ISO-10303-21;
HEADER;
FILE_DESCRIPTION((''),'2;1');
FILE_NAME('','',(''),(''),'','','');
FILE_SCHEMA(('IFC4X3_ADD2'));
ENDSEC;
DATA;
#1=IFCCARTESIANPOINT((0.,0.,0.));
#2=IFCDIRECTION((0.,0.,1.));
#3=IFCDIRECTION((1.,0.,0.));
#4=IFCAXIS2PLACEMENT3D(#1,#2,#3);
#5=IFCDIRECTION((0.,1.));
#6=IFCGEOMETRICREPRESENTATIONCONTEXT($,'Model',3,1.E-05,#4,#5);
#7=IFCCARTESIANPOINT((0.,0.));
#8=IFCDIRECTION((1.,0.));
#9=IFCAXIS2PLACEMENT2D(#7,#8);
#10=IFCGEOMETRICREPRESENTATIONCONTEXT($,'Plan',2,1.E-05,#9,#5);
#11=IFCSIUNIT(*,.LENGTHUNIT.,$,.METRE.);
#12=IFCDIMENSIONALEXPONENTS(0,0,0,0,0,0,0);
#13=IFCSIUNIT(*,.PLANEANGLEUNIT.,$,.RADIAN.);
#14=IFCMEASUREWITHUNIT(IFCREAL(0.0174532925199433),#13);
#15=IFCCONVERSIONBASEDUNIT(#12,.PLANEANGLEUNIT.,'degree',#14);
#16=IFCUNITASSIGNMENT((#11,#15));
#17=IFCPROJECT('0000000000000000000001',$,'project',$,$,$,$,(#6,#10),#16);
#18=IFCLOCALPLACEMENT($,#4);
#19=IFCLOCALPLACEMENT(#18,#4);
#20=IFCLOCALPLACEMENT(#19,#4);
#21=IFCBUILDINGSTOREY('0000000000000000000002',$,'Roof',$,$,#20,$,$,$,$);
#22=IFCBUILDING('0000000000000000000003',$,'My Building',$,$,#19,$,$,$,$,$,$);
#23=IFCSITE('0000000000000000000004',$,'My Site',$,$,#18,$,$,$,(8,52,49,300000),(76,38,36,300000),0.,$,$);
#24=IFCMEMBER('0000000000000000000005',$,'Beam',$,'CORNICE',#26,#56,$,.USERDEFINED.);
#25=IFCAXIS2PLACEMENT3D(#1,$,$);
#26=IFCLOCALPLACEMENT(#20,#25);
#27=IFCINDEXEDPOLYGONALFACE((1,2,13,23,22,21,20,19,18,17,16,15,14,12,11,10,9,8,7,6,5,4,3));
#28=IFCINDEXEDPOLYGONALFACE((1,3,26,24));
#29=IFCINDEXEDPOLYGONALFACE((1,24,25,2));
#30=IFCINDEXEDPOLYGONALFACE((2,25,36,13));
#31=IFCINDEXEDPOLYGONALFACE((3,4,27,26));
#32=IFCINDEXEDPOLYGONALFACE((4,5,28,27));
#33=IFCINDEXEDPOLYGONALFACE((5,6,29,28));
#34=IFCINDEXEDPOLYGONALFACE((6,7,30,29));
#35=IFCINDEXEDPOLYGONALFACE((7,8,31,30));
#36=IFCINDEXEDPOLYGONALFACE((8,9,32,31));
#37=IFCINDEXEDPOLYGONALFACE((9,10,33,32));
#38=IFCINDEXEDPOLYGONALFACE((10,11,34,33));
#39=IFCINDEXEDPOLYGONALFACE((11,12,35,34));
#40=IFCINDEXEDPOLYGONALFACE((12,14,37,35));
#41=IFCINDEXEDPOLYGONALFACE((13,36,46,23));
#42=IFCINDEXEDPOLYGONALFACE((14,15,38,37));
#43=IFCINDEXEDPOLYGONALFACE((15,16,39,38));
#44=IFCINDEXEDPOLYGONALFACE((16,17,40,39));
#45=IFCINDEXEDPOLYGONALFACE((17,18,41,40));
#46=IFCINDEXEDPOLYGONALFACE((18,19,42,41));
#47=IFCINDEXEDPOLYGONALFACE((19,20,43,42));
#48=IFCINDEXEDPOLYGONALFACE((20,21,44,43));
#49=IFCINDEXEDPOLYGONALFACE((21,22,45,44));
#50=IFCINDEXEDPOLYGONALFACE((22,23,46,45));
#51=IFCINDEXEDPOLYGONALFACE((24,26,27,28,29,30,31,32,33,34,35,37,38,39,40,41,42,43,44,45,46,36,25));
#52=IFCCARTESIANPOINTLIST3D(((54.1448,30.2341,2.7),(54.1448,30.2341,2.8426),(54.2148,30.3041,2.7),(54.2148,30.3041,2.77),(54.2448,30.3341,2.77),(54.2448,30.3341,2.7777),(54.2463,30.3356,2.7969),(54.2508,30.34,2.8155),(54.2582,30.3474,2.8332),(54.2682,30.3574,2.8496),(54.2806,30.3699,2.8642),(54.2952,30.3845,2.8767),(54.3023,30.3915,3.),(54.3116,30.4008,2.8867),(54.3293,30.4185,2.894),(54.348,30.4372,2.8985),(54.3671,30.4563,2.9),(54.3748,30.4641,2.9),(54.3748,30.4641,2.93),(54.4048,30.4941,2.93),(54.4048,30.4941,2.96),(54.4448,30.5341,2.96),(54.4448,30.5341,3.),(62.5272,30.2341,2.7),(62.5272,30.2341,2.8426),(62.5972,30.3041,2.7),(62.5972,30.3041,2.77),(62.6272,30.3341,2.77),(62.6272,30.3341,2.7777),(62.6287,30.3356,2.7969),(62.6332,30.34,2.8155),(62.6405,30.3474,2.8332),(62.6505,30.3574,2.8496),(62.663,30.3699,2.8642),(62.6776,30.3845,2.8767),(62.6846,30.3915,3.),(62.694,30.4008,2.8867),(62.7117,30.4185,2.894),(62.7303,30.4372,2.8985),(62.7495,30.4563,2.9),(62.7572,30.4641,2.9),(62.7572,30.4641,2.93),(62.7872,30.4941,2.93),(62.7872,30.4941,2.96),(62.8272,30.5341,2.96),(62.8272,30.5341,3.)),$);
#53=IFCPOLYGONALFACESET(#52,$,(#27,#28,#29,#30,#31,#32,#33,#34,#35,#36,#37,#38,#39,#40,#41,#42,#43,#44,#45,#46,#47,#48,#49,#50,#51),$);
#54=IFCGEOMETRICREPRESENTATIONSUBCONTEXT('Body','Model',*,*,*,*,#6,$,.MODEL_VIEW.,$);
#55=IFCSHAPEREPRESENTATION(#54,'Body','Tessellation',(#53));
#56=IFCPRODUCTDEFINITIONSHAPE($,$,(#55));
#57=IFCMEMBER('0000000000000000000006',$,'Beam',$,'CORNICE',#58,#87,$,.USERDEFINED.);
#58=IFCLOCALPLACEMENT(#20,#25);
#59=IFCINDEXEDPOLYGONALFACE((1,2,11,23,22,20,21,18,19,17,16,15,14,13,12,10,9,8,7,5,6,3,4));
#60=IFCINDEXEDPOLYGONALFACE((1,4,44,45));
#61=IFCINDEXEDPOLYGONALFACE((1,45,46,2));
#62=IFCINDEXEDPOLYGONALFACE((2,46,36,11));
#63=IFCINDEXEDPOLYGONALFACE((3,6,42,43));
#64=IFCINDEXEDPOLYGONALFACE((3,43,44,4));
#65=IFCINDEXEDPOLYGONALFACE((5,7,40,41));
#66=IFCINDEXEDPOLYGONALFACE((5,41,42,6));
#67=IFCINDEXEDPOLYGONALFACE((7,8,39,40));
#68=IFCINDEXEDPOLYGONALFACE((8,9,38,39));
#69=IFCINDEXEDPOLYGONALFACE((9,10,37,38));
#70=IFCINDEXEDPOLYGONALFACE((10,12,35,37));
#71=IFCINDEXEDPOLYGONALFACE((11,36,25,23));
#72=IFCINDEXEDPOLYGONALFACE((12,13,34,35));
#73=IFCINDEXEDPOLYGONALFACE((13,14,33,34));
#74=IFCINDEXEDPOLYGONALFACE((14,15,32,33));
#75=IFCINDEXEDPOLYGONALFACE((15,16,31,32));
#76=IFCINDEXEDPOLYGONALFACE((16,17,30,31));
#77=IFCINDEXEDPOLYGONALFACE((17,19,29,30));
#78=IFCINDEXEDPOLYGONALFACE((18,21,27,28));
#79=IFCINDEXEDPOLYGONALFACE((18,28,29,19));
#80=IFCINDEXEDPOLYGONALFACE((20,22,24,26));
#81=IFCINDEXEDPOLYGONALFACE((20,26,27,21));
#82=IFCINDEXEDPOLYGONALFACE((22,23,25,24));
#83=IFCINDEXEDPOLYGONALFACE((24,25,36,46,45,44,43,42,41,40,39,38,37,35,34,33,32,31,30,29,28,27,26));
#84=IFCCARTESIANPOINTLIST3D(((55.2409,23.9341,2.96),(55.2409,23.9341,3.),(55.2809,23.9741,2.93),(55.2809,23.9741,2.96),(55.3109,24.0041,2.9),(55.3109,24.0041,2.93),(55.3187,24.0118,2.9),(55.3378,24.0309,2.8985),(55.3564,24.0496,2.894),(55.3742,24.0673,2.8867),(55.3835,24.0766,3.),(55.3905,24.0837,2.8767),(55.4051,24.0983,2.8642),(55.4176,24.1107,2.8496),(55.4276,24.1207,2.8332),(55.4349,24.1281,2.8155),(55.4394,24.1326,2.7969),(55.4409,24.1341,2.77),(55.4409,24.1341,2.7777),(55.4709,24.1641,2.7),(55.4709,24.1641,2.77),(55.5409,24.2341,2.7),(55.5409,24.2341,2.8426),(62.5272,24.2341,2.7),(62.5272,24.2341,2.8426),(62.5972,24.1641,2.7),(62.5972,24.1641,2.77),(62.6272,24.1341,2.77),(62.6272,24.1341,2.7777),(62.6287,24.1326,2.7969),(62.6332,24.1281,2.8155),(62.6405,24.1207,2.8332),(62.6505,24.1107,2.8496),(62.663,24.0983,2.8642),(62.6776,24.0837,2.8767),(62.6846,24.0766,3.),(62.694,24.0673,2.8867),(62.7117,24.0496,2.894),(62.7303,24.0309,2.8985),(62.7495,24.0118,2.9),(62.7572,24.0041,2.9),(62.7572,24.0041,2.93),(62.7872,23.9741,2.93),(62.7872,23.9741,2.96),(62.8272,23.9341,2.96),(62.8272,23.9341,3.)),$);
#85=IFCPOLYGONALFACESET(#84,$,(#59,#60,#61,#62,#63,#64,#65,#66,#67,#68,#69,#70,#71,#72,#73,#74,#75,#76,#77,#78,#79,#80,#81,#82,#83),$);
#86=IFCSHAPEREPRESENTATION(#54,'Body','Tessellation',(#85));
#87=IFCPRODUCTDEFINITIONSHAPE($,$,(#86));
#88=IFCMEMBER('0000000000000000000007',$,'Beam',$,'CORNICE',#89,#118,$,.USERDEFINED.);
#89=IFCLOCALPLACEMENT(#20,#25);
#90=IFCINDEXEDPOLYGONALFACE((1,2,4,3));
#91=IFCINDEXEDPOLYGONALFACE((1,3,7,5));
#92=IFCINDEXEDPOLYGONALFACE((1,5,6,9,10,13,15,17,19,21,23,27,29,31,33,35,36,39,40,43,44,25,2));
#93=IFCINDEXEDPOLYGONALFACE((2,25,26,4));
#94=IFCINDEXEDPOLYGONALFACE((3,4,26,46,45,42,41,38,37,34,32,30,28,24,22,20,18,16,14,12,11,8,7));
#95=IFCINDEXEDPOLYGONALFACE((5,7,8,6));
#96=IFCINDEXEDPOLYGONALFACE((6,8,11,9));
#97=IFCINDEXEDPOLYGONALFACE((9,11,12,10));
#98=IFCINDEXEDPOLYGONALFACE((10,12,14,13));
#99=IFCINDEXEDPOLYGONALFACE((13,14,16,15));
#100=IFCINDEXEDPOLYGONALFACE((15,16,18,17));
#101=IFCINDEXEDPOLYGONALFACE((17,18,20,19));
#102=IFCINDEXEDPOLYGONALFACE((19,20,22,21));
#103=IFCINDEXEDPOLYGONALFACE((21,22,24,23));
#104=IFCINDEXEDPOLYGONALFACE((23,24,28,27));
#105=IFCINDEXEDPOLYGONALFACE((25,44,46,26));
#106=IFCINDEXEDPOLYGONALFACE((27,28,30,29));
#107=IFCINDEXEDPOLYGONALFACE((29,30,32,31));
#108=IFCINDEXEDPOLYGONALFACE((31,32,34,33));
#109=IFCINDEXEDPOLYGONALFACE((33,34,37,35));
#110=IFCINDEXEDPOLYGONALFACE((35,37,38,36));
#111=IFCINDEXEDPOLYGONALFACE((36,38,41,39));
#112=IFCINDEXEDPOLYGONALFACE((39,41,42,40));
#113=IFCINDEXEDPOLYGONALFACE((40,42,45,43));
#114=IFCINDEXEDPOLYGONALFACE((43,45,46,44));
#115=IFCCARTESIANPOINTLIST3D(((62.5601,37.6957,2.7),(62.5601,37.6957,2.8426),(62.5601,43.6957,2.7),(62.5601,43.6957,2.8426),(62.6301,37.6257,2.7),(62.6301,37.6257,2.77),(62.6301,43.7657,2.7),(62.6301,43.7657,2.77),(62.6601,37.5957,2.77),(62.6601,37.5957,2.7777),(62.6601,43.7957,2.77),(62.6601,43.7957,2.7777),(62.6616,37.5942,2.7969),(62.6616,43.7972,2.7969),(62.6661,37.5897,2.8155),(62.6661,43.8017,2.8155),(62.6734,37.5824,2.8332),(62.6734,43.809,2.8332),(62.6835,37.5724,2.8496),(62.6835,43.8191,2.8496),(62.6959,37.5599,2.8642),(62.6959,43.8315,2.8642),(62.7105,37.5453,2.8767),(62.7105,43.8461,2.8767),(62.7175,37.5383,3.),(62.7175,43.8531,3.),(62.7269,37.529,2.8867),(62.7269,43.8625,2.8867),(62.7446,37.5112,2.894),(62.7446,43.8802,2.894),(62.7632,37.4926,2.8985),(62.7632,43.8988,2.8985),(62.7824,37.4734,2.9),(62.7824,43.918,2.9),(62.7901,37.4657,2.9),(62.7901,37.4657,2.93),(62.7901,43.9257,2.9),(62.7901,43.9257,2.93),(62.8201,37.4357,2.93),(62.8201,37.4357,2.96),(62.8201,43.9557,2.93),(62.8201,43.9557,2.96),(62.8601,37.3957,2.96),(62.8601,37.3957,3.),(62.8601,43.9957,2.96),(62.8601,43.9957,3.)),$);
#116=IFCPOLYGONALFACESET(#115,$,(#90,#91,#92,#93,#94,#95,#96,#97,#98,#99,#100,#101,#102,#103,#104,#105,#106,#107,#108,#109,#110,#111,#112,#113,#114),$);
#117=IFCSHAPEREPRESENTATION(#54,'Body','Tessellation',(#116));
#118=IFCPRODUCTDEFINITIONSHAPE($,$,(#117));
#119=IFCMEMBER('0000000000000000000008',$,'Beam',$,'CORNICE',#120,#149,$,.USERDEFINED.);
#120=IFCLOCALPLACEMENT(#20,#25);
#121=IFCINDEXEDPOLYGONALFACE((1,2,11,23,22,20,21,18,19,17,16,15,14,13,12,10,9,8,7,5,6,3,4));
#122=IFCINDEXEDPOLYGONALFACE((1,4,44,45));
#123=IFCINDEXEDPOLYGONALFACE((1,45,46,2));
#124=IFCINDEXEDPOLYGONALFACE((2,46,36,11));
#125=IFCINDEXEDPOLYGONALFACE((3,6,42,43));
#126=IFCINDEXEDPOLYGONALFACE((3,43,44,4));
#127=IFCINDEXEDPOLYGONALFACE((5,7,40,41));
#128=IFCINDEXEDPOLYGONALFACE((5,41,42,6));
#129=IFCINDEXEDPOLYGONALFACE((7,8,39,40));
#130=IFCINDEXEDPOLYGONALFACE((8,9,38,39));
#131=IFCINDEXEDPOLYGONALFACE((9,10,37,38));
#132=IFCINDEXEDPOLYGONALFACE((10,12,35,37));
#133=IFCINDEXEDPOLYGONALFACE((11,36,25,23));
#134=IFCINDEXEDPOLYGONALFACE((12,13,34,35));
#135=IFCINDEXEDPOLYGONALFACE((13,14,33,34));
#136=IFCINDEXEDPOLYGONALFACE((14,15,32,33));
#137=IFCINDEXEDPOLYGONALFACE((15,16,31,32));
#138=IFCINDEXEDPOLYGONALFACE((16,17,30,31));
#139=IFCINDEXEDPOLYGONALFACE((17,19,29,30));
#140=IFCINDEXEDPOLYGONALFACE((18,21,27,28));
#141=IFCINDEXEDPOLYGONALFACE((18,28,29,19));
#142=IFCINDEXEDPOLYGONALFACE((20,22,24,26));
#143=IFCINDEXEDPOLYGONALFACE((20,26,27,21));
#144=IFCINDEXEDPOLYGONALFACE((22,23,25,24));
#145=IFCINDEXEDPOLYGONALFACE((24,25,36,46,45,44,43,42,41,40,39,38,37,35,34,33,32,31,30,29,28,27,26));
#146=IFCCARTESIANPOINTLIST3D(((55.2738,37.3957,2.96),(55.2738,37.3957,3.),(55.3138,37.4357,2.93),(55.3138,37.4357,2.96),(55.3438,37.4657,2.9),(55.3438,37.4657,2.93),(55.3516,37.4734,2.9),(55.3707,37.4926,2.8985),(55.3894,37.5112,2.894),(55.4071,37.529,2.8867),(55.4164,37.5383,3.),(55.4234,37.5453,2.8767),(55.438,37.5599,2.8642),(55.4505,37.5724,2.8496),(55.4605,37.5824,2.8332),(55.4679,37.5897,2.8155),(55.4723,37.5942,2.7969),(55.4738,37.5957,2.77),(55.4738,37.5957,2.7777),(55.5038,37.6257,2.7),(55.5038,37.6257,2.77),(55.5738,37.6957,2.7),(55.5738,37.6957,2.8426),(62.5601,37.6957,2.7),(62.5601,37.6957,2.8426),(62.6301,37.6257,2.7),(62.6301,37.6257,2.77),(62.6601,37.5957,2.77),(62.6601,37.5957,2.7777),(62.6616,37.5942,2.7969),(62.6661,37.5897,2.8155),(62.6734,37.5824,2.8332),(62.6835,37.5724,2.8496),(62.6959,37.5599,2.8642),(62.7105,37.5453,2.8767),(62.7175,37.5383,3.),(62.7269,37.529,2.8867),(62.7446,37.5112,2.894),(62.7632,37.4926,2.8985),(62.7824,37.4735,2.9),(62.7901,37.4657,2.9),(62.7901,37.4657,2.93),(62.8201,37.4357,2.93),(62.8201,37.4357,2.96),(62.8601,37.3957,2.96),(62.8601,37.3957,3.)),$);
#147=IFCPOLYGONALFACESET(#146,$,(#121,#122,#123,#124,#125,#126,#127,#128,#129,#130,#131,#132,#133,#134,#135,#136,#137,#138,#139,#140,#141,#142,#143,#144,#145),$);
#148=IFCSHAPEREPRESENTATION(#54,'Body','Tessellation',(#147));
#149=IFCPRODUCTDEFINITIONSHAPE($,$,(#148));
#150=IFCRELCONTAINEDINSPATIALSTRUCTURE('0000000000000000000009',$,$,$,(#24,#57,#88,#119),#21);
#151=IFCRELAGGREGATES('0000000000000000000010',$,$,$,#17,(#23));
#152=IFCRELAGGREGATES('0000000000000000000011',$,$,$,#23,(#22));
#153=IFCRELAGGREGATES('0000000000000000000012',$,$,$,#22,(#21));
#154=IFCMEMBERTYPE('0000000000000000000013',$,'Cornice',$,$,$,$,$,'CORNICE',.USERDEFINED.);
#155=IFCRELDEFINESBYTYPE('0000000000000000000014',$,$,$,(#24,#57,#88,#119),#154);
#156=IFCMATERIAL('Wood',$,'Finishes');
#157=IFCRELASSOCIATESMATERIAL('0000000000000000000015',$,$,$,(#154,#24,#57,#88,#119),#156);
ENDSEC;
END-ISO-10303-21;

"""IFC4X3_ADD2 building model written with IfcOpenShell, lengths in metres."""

from ifc_helpers import new_model, entity, si_unit, converted_unit, direction, frame, origin_with_axes, origin_2d_with_axis, place, context, subcontext, project, spatial, indexed_curve, outline, extrude, clip, halfspace, material, material_profile, profile_set, profile_usage, type_object, element, save


model = new_model("IFC4X3_ADD2")

# Units and contexts
model_context = context("Model", 3, precision=1e-05, world=origin_with_axes(), true_north=direction((0.0, 1.0)))
plan_context = context("Plan", 2, precision=1e-05, world=origin_2d_with_axis(), true_north=direction((0.0, 1.0)))
body_context = subcontext(model_context, "Body", "Model", "MODEL_VIEW")
ifc_project = project(units=[si_unit("LENGTHUNIT", "METRE"), converted_unit("PLANEANGLEUNIT", "degree", entity("IfcReal", 0.0174532925199433), si_unit("PLANEANGLEUNIT", "RADIAN"), dimensions=[0, 0, 0, 0, 0, 0, 0])], contexts=[model_context, plan_context])

# Site, building, storey
site_placement = place(None, origin_with_axes())
site = spatial("IfcSite", under=ifc_project, at=site_placement, Name="My Site", RefLatitude=(8, 52, 49, 300000), RefLongitude=(76, 38, 36, 300000), RefElevation=0.0)
building_placement = place(site_placement, origin_with_axes())
building = spatial("IfcBuilding", under=site, at=building_placement, Name="My Building")
storey_placement = place(building_placement, origin_with_axes())
storey = spatial("IfcBuildingStorey", under=building, at=storey_placement, Name="Roof")

# Members
ifc_material_1 = material(Name="Wood", Category="Finishes")
ifc_material_profile_1 = material_profile(ifc_material_1, outline(indexed_curve([(-0.26, 0.26), (-0.3, 0.26), (-0.3, 0.3), (-0.1574, 0.3), (0.0, 0.1426), (0.0, 0.0), (-0.07, 0.0), (-0.07, 0.07), (-0.1, 0.07), (-0.1, 0.0777), (-0.1015, 0.0969), (-0.106, 0.1155), (-0.1133, 0.1332), (-0.1233, 0.1496), (-0.1358, 0.1642), (-0.1504, 0.1767), (-0.1668, 0.1867), (-0.1845, 0.194), (-0.2031, 0.1985), (-0.2223, 0.2), (-0.23, 0.2), (-0.23, 0.23), (-0.26, 0.23), (-0.26, 0.26)])))
ifc_profile_set_1 = profile_set([ifc_material_profile_1])
member_type = type_object("IfcMemberType", Name="Cornice", ElementType="CORNICE", PredefinedType="USERDEFINED", material=ifc_profile_set_1)
ifc_profile_usage_1 = profile_usage(ifc_profile_set_1, cardinal=5)
member_1_placement = place(storey_placement, frame((62.8272, 30.2341, 2.7), z_axis=(-1.0, 0.0, 0.0), x_axis=(0.0, -1.0, 0.0)))
element("IfcMember", 1, at=member_1_placement, inside=storey, type_object=member_type, material=ifc_profile_usage_1, Name="Beam", ObjectType="CORNICE", PredefinedType="USERDEFINED", context=body_context, shape_type="Clipping", body=[
    clip(clip(extrude(outline(indexed_curve([(-0.26, 0.26), (-0.3, 0.26), (-0.3, 0.3), (-0.1574, 0.3), (0.0, 0.1426), (0.0, 0.0), (-0.07, 0.0), (-0.07, 0.07), (-0.1, 0.07), (-0.1, 0.0777), (-0.1015, 0.0969), (-0.106, 0.1155), (-0.1133, 0.1332), (-0.1233, 0.1496), (-0.1358, 0.1642), (-0.1504, 0.1767), (-0.1668, 0.1867), (-0.1845, 0.194), (-0.2031, 0.1985), (-0.2223, 0.2), (-0.23, 0.2), (-0.23, 0.23), (-0.26, 0.23), (-0.26, 0.26)])), origin_with_axes(), (0.0, 0.0, 1.0), 8.6824), halfspace(frame((0.0, -2.7, 8.6824), z_axis=(-0.707107, 0.0, 0.707107), x_axis=(0.0, 1.0, 0.0)), False)), halfspace(frame((-0.3, -2.7, 0.0), z_axis=(0.707107, 0.0, -0.707107), x_axis=(0.0, -1.0, 0.0)), False)),
])
ifc_profile_usage_2 = profile_usage(ifc_profile_set_1, cardinal=5)
member_2_placement = place(storey_placement, frame((55.2409, 24.2341, 2.7), z_axis=(1.0, 0.0, 0.0), x_axis=(0.0, 1.0, 0.0)))
element("IfcMember", 2, at=member_2_placement, inside=storey, type_object=member_type, material=ifc_profile_usage_2, Name="Beam", ObjectType="CORNICE", PredefinedType="USERDEFINED", context=body_context, shape_type="Clipping", body=[
    clip(clip(extrude(outline(indexed_curve([(-0.26, 0.26), (-0.3, 0.26), (-0.3, 0.3), (-0.1574, 0.3), (0.0, 0.1426), (0.0, 0.0), (-0.07, 0.0), (-0.07, 0.07), (-0.1, 0.07), (-0.1, 0.0777), (-0.1015, 0.0969), (-0.106, 0.1155), (-0.1133, 0.1332), (-0.1233, 0.1496), (-0.1358, 0.1642), (-0.1504, 0.1767), (-0.1668, 0.1867), (-0.1845, 0.194), (-0.2031, 0.1985), (-0.2223, 0.2), (-0.23, 0.2), (-0.23, 0.23), (-0.26, 0.23), (-0.26, 0.26)])), origin_with_axes(), (0.0, 0.0, 1.0), 7.5863), halfspace(frame((-0.3, -2.7, 7.5863), z_axis=(0.707107, 0.0, 0.707107), x_axis=(0.0, -1.0, 0.0)), False)), halfspace(frame((-0.3, -2.7, 0.0), z_axis=(0.707107, 0.0, -0.707107), x_axis=(0.0, -1.0, 0.0)), False)),
])
ifc_profile_usage_3 = profile_usage(ifc_profile_set_1, cardinal=5)
member_3_placement = place(storey_placement, frame((62.5601, 37.3957, 2.7), z_axis=(0.0, 1.0, 0.0), x_axis=(-1.0, 0.0, 0.0)))
element("IfcMember", 3, at=member_3_placement, inside=storey, type_object=member_type, material=ifc_profile_usage_3, Name="Beam", ObjectType="CORNICE", PredefinedType="USERDEFINED", context=body_context, shape_type="Clipping", body=[
    clip(clip(extrude(outline(indexed_curve([(-0.26, 0.26), (-0.3, 0.26), (-0.3, 0.3), (-0.1574, 0.3), (0.0, 0.1426), (0.0, 0.0), (-0.07, 0.0), (-0.07, 0.07), (-0.1, 0.07), (-0.1, 0.0777), (-0.1015, 0.0969), (-0.106, 0.1155), (-0.1133, 0.1332), (-0.1233, 0.1496), (-0.1358, 0.1642), (-0.1504, 0.1767), (-0.1668, 0.1867), (-0.1845, 0.194), (-0.2031, 0.1985), (-0.2223, 0.2), (-0.23, 0.2), (-0.23, 0.23), (-0.26, 0.23), (-0.26, 0.26)])), origin_with_axes(), (0.0, 0.0, 1.0), 6.6), halfspace(frame((-0.3, -2.7, 6.6), z_axis=(0.707107, 0.0, 0.707107), x_axis=(0.0, -1.0, 0.0)), False)), halfspace(frame((-0.3, -2.7, 0.0), z_axis=(0.707107, 0.0, -0.707107), x_axis=(0.0, -1.0, 0.0)), False)),
])
ifc_profile_usage_4 = profile_usage(ifc_profile_set_1, cardinal=5)
member_4_placement = place(storey_placement, frame((55.2738, 37.6957, 2.7), z_axis=(1.0, 0.0, 0.0), x_axis=(0.0, 1.0, 0.0)))
element("IfcMember", 4, at=member_4_placement, inside=storey, type_object=member_type, material=ifc_profile_usage_4, Name="Beam", ObjectType="CORNICE", PredefinedType="USERDEFINED", context=body_context, shape_type="Clipping", body=[
    clip(clip(extrude(outline(indexed_curve([(-0.26, 0.26), (-0.3, 0.26), (-0.3, 0.3), (-0.1574, 0.3), (0.0, 0.1426), (0.0, 0.0), (-0.07, 0.0), (-0.07, 0.07), (-0.1, 0.07), (-0.1, 0.0777), (-0.1015, 0.0969), (-0.106, 0.1155), (-0.1133, 0.1332), (-0.1233, 0.1496), (-0.1358, 0.1642), (-0.1504, 0.1767), (-0.1668, 0.1867), (-0.1845, 0.194), (-0.2031, 0.1985), (-0.2223, 0.2), (-0.23, 0.2), (-0.23, 0.23), (-0.26, 0.23), (-0.26, 0.26)])), origin_with_axes(), (0.0, 0.0, 1.0), 7.5863), halfspace(frame((-0.3, -2.7, 0.0), z_axis=(0.707107, 0.0, -0.707107), x_axis=(0.0, -1.0, 0.0)), False)), halfspace(frame((-0.3, -2.7, 7.5863), z_axis=(0.707107, 0.0, 0.707107), x_axis=(0.0, -1.0, 0.0)), False)),
])

save(model, "model.ifc")
